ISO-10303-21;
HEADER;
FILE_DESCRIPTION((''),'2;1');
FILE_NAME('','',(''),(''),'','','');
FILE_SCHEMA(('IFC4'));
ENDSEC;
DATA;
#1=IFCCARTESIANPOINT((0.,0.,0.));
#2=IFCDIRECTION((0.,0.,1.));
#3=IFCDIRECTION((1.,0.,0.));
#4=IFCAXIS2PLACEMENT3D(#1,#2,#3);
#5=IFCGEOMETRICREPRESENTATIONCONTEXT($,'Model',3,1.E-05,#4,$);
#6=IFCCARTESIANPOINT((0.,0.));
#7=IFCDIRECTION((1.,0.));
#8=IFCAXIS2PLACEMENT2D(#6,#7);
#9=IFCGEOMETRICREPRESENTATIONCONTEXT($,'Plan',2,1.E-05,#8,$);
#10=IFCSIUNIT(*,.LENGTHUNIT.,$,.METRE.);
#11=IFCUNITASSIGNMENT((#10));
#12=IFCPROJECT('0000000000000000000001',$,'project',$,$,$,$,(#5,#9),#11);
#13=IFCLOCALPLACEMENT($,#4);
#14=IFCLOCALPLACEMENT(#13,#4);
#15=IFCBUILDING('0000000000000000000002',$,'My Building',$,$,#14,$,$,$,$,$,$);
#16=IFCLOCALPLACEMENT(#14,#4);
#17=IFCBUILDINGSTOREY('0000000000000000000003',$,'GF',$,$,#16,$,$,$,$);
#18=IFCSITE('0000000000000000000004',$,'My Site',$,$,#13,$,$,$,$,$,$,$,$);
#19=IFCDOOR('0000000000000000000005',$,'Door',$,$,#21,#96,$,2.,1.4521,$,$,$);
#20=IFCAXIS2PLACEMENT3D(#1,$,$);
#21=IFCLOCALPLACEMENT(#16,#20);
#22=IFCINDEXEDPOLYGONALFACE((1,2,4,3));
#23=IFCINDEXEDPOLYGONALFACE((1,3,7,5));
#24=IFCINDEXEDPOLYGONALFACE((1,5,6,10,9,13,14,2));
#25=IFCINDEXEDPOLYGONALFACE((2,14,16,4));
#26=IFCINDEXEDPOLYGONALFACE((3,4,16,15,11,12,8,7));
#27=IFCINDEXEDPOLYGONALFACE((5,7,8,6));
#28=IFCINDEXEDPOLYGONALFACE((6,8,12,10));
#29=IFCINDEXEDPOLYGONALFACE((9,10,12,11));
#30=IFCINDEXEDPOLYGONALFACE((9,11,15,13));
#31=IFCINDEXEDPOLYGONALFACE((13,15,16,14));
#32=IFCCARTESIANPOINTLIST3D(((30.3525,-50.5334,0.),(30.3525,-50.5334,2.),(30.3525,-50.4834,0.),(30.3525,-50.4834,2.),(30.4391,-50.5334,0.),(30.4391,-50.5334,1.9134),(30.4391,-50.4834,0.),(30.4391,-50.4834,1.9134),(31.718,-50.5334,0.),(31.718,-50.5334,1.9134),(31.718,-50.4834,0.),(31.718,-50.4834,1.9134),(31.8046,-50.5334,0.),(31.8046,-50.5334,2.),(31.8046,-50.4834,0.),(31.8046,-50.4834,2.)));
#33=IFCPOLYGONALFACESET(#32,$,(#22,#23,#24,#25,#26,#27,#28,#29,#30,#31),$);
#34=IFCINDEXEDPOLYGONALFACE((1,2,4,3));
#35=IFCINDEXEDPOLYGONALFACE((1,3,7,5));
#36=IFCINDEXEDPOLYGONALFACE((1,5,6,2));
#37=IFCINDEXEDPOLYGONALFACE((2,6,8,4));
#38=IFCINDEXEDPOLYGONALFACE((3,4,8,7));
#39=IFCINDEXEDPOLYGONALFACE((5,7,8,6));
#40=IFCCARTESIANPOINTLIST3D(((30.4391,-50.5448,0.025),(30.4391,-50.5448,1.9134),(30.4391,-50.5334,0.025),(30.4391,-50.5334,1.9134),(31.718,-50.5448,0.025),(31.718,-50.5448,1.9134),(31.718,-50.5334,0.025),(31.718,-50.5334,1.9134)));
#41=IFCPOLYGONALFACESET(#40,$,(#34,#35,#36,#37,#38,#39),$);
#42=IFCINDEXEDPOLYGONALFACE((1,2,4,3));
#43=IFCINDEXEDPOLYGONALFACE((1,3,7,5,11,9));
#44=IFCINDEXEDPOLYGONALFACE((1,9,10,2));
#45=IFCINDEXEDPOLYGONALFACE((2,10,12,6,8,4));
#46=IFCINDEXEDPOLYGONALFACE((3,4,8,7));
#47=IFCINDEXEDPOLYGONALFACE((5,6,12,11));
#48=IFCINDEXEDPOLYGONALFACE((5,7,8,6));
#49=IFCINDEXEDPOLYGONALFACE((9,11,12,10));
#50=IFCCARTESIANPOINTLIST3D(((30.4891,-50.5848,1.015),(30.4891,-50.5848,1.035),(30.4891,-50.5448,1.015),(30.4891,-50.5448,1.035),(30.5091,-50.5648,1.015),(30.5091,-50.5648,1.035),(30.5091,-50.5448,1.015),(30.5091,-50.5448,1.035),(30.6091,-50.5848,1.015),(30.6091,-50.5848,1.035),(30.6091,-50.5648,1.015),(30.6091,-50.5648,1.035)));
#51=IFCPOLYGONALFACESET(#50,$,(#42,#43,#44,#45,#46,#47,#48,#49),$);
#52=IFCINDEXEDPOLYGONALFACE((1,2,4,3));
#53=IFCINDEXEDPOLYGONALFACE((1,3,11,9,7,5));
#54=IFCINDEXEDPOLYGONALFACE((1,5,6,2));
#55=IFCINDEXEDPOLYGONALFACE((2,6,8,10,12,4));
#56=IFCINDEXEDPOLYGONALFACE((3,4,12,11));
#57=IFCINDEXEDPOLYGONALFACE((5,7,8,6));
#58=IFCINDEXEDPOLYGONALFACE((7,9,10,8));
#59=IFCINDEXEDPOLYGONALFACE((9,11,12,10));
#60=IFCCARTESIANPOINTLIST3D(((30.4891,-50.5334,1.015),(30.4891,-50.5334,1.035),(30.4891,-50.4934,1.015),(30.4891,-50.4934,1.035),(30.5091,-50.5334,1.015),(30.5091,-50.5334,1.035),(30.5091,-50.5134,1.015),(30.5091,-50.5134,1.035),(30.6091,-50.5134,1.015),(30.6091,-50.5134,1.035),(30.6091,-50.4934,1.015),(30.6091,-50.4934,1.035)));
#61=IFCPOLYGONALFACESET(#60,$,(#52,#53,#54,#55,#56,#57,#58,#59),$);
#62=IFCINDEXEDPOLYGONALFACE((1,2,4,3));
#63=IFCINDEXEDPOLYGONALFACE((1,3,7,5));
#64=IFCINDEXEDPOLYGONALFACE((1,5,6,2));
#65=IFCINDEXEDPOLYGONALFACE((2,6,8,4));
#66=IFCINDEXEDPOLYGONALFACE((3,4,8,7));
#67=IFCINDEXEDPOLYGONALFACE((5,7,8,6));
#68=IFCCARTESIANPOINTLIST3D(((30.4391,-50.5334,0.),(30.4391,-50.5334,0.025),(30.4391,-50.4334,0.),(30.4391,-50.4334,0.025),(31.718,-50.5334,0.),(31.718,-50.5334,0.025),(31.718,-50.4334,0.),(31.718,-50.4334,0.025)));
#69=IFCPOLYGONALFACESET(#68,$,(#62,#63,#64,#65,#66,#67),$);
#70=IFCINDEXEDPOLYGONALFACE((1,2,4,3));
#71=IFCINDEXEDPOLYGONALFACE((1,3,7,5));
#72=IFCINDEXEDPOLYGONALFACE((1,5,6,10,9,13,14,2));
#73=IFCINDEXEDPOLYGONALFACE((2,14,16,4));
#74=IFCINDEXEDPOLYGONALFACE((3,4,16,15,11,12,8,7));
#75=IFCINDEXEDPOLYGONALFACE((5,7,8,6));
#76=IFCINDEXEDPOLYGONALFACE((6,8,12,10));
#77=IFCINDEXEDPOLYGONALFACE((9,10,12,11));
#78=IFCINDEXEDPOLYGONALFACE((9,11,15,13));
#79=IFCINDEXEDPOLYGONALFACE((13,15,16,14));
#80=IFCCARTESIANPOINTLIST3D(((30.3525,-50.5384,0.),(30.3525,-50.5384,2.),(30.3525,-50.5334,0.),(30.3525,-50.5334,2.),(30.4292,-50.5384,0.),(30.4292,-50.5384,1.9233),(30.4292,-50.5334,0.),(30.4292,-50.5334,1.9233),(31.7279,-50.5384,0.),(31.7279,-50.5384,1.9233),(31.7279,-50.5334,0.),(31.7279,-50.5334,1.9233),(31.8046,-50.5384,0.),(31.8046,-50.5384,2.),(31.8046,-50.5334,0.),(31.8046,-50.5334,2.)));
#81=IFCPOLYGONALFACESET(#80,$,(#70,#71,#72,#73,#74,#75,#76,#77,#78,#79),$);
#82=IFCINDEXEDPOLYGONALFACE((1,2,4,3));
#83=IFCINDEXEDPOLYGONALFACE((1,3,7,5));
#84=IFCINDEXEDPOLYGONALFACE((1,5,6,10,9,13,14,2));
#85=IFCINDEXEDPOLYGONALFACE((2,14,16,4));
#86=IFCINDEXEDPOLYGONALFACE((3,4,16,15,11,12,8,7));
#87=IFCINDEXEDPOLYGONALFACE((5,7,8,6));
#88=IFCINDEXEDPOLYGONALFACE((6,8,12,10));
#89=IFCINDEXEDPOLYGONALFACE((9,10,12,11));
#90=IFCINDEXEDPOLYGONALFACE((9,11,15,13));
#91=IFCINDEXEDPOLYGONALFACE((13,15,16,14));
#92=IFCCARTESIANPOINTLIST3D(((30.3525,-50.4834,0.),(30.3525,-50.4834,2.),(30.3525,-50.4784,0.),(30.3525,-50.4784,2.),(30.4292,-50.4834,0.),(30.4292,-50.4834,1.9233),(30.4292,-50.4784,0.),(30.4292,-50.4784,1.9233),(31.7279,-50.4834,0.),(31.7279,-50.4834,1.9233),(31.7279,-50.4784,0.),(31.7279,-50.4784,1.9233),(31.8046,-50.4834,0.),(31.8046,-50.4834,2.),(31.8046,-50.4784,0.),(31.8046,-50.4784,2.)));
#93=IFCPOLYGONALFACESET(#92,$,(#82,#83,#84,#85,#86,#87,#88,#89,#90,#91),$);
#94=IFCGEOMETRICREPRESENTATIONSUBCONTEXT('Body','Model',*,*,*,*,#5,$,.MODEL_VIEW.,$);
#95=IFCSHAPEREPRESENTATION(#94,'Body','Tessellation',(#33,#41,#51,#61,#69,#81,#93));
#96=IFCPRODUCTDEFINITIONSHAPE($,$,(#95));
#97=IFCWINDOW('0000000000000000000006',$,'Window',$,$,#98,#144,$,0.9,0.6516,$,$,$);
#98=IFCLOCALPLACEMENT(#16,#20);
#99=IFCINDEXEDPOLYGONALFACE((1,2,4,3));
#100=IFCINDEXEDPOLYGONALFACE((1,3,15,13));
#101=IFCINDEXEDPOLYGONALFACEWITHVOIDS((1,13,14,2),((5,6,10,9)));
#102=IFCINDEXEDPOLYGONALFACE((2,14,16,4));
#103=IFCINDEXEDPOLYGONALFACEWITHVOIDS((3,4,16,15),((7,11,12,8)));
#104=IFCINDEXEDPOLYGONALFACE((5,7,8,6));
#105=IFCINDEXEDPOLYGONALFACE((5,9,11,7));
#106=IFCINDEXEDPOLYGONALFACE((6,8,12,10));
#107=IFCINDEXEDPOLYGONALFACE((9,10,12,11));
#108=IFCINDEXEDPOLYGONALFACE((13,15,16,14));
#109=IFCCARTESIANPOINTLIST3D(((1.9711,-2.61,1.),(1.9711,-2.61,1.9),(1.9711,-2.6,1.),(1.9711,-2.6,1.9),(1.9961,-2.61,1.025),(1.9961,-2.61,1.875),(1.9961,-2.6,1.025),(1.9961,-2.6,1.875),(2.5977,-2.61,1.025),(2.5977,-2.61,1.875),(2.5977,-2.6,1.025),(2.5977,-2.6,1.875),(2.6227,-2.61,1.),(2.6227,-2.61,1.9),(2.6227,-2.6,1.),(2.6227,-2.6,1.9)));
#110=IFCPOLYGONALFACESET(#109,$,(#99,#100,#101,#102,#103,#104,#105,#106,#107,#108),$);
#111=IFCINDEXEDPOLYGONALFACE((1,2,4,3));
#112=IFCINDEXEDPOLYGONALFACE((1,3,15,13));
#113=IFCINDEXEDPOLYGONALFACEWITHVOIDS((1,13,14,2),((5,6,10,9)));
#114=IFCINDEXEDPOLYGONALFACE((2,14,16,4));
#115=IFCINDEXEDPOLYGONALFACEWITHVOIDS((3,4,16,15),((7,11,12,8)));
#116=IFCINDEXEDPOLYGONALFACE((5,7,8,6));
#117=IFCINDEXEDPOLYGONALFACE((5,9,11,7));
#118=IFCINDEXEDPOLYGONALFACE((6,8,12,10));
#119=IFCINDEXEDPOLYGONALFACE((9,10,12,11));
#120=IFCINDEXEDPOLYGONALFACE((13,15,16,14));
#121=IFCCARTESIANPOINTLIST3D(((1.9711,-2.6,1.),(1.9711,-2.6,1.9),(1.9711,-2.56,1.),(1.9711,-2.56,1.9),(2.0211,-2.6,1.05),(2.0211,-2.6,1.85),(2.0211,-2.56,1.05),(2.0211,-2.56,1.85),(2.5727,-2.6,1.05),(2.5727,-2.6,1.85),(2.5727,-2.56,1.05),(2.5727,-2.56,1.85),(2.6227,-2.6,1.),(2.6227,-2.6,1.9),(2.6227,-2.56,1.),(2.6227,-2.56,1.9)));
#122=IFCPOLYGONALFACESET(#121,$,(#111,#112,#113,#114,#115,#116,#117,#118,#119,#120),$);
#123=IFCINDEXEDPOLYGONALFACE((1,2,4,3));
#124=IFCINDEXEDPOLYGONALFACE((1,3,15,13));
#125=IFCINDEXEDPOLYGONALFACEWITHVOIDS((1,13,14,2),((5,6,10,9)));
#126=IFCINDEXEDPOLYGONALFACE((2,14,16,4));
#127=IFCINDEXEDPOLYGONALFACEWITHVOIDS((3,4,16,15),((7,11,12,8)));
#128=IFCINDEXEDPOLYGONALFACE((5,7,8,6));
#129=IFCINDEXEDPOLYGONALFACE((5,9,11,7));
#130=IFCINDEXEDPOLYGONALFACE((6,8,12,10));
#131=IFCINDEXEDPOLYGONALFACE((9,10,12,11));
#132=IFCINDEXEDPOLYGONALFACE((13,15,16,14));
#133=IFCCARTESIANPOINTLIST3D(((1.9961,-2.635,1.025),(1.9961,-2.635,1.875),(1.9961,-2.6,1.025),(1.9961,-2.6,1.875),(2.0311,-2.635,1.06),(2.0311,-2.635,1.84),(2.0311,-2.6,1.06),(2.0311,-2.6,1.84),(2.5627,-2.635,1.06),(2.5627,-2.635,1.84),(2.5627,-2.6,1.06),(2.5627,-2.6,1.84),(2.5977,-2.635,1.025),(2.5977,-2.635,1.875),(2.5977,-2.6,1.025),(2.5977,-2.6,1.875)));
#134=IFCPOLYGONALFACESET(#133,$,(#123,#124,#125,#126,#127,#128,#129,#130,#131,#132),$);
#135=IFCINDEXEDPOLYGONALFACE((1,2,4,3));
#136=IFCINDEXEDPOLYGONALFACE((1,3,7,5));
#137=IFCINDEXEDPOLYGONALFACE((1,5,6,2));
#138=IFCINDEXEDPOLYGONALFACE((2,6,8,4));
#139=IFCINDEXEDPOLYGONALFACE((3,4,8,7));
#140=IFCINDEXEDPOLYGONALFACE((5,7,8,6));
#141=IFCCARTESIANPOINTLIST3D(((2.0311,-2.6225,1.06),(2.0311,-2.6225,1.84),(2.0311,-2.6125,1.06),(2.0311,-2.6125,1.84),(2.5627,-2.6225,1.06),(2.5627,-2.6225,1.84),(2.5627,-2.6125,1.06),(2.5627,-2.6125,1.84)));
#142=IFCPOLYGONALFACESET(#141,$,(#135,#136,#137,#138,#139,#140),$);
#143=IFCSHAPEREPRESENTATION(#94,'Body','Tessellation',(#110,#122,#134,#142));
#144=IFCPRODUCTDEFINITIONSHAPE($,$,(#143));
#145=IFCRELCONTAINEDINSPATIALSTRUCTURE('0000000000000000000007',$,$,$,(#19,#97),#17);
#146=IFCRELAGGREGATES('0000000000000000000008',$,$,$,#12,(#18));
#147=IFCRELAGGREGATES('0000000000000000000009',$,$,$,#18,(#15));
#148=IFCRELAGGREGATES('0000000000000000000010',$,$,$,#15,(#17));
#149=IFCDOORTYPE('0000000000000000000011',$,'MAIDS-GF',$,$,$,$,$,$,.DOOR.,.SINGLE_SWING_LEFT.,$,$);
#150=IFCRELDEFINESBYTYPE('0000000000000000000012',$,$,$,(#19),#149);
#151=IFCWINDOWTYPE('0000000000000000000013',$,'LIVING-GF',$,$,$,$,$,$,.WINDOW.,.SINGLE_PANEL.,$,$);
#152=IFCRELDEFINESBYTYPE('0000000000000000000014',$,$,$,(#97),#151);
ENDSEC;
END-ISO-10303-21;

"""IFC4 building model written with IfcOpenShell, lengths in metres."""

from ifc_helpers import new_model, entity, si_unit, frame, origin_with_axes, origin_2d_with_axis, place, context, subcontext, project, spatial, line, indexed_curve, outline, extrude, shape, source, transform, mapped, type_object, type_shapes, element, save


model = new_model("IFC4")

# Units and contexts
model_context = context("Model", 3, precision=1e-05, world=origin_with_axes())
plan_context = context("Plan", 2, precision=1e-05, world=origin_2d_with_axis())
body_context_1 = subcontext(model_context, "Body", "Model", "MODEL_VIEW")
body_context_2 = subcontext(plan_context, "Body", "Plan", "PLAN_VIEW")
ifc_project = project(units=[si_unit("LENGTHUNIT", "METRE")], contexts=[model_context, plan_context])

# Site, building, storey
site_placement = place(None, origin_with_axes())
site = spatial("IfcSite", under=ifc_project, at=site_placement, Name="My Site")
building_placement = place(site_placement, origin_with_axes())
building = spatial("IfcBuilding", under=site, at=building_placement, Name="My Building")
storey_placement = place(building_placement, origin_with_axes())
storey = spatial("IfcBuildingStorey", under=building, at=storey_placement, Name="GF")

# Shared definitions
wall_1_placement = place(storey_placement, frame((0.2283, -2.61, 0.0), z_axis=(0.0, 0.0, 1.0), x_axis=(1.0, 0.0, 0.0)))
window_type_1 = type_object("IfcWindowType", Name="LIVING-GF", PartitioningType="SINGLE_PANEL", PredefinedType="WINDOW")
shared_shape_1 = source(origin_with_axes(), body_context_1, "Body", "SweptSolid", [
    extrude(outline(indexed_curve([(0.0, 0.0), (0.6516, 0.0), (0.6516, 0.9), (0.0, 0.9)], segments=[line(1, 2, 3, 4, 1)]), holes=[indexed_curve([(0.025, 0.025), (0.6266, 0.025), (0.6266, 0.875), (0.025, 0.875)], segments=[line(1, 2, 3, 4, 1)])]), frame((0.0, 0.09, 0.0), z_axis=(0.0, -1.0, 0.0), x_axis=(1.0, 0.0, 0.0)), (0.0, 0.0, -1.0), 0.01),
    extrude(outline(indexed_curve([(0.0, 0.0), (0.6516, 0.0), (0.6516, 0.9), (0.0, 0.9)], segments=[line(1, 2, 3, 4, 1)]), holes=[indexed_curve([(0.05, 0.05), (0.6016, 0.05), (0.6016, 0.85), (0.05, 0.85)], segments=[line(1, 2, 3, 4, 1)])]), frame((0.0, 0.05, 0.0), z_axis=(0.0, -1.0, 0.0), x_axis=(1.0, 0.0, 0.0)), (0.0, 0.0, -1.0), 0.04),
    extrude(outline(indexed_curve([(0.0, 0.0), (0.6016, 0.0), (0.6016, 0.85), (0.0, 0.85)], segments=[line(1, 2, 3, 4, 1)]), holes=[indexed_curve([(0.035, 0.035), (0.5666, 0.035), (0.5666, 0.815), (0.035, 0.815)], segments=[line(1, 2, 3, 4, 1)])]), frame((0.025, 0.09, 0.025), z_axis=(0.0, -1.0, 0.0), x_axis=(1.0, 0.0, 0.0)), (0.0, 0.0, -1.0), 0.035),
    extrude(outline(indexed_curve([(0.035, 0.035), (0.5666, 0.035), (0.5666, 0.815), (0.035, 0.815)], segments=[line(1, 2, 3, 4, 1)])), frame((0.025, 0.1025, 0.025), z_axis=(0.0, -1.0, 0.0), x_axis=(1.0, 0.0, 0.0)), (0.0, 0.0, -1.0), 0.01),
])
shared_shape_2 = source(origin_with_axes(), body_context_2, "Body", "Curve2D", [
    entity("IfcIndexedPolyCurve", entity("IfcCartesianPointList2D", [[0.05, 0.05], [0.6016, 0.05]])),
    entity("IfcIndexedPolyCurve", entity("IfcCartesianPointList2D", [[0.0, 0.1], [0.025, 0.1], [0.025, 0.09], [0.05, 0.09], [0.05, 0.05], [0.0, 0.05]]), [entity("IfcLineIndex", [1, 2, 3, 4, 5, 6, 1])]),
    entity("IfcIndexedPolyCurve", entity("IfcCartesianPointList2D", [[0.6516, 0.1], [0.6266, 0.1], [0.6266, 0.09], [0.6016, 0.09], [0.6016, 0.05], [0.6516, 0.05]]), [entity("IfcLineIndex", [1, 2, 3, 4, 5, 6, 1])]),
    entity("IfcIndexedPolyCurve", entity("IfcCartesianPointList2D", [[0.025, 0.09], [0.06, 0.09], [0.06, 0.125], [0.025, 0.125]]), [entity("IfcLineIndex", [1, 2, 3, 4, 1])]),
    entity("IfcIndexedPolyCurve", entity("IfcCartesianPointList2D", [[0.6266, 0.09], [0.5916, 0.09], [0.5916, 0.125], [0.6266, 0.125]]), [entity("IfcLineIndex", [1, 2, 3, 4, 1])]),
    entity("IfcIndexedPolyCurve", entity("IfcCartesianPointList2D", [[0.06, 0.09], [0.5916, 0.09]])),
    entity("IfcIndexedPolyCurve", entity("IfcCartesianPointList2D", [[0.06, 0.125], [0.5916, 0.125]])),
    entity("IfcIndexedPolyCurve", entity("IfcCartesianPointList2D", [[0.06, 0.1075], [0.5916, 0.1075]])),
])
type_shapes(window_type_1, [shared_shape_1, shared_shape_2])

# Door
door_type_1 = type_object("IfcDoorType", Name="MAIDS-GF", OperationType="SINGLE_SWING_LEFT", PredefinedType="DOOR")
shared_shape_3 = source(origin_with_axes(), body_context_1, "Body", "SweptSolid", [
    extrude(outline(indexed_curve([(0.0, 0.0), (0.0, 2.0), (1.4521, 2.0), (1.4521, 0.0), (1.3655, 0.0), (1.3655, 1.9134), (0.0866, 1.9134), (0.0866, 0.0)], segments=[line(1, 2, 3, 4, 5, 6, 7, 8, 1)])), frame((0.0, 0.0, 0.0), z_axis=(0.0, -1.0, 0.0), x_axis=(1.0, 0.0, 0.0)), (0.0, 0.0, -1.0), 0.05),
    extrude(outline(indexed_curve([(0.0, 0.0), (1.2788, 0.0), (1.2788, 0.0114), (0.0, 0.0114)], segments=[line(1, 2, 3, 4, 1)])), frame((0.0866, -0.0114, 0.025), z_axis=(0.0, 0.0, 1.0), x_axis=(1.0, 0.0, 0.0)), (0.0, 0.0, 1.0), 1.8884),
    extrude(outline(indexed_curve([(0.0, 0.0), (0.0, -0.04), (0.12, -0.04), (0.12, -0.02), (0.02, -0.02), (0.02, 0.0)], segments=[line(1, 2, 3, 4, 5, 6, 1)])), frame((0.1366, -0.0114, 1.015), z_axis=(0.0, 0.0, 1.0), x_axis=(1.0, 0.0, 0.0)), (0.0, 0.0, 1.0), 0.02),
    extrude(outline(indexed_curve([(0.0, 0.0), (0.0, 0.04), (0.12, 0.04), (0.12, 0.02), (0.02, 0.02), (0.02, 0.0)], segments=[line(1, 2, 3, 4, 5, 6, 1)])), frame((0.1366, 0.0, 1.015), z_axis=(0.0, 0.0, 1.0), x_axis=(1.0, 0.0, 0.0)), (0.0, 0.0, 1.0), 0.02),
    extrude(outline(indexed_curve([(0.0, 0.0), (1.2788, 0.0), (1.2788, 0.1), (0.0, 0.1)], segments=[line(1, 2, 3, 4, 1)])), frame((0.0866, 0.0, 0.0), z_axis=(0.0, 0.0, 1.0), x_axis=(1.0, 0.0, 0.0)), (0.0, 0.0, 1.0), 0.025),
    extrude(outline(indexed_curve([(0.0, 0.0), (0.0, 2.0), (1.4521, 2.0), (1.4521, 0.0), (1.3754, 0.0), (1.3754, 1.9233), (0.0767, 1.9233), (0.0767, 0.0)], segments=[line(1, 2, 3, 4, 5, 6, 7, 8, 1)])), frame((0.0, -0.005, 0.0), z_axis=(0.0, -1.0, 0.0), x_axis=(1.0, 0.0, 0.0)), (0.0, 0.0, -1.0), 0.005),
    extrude(outline(indexed_curve([(0.0, 0.0), (0.0, 2.0), (1.4521, 2.0), (1.4521, 0.0), (1.3754, 0.0), (1.3754, 1.9233), (0.0767, 1.9233), (0.0767, 0.0)], segments=[line(1, 2, 3, 4, 5, 6, 7, 8, 1)])), frame((0.0, 0.05, 0.0), z_axis=(0.0, -1.0, 0.0), x_axis=(1.0, 0.0, 0.0)), (0.0, 0.0, -1.0), 0.005),
])
shared_shape_4 = source(origin_with_axes(), body_context_2, "Body", "Curve2D", [
    entity("IfcIndexedPolyCurve", entity("IfcCartesianPointList2D", [[0.0, 0.0], [0.0866, 0.0], [0.0866, 0.05], [0.0, 0.05]]), [entity("IfcLineIndex", [1, 2, 3, 4, 1])]),
    entity("IfcIndexedPolyCurve", entity("IfcCartesianPointList2D", [[1.4521, 0.0], [1.3655, 0.0], [1.3655, 0.05], [1.4521, 0.05]]), [entity("IfcLineIndex", [1, 2, 3, 4, 1])]),
    entity("IfcIndexedPolyCurve", entity("IfcCartesianPointList2D", [[2.0049, -0.0114], [0.7261, -0.0114], [0.7261, 0.0], [2.0049, 0.0]]), [entity("IfcLineIndex", [1, 2, 3, 4, 1])]),
])
type_shapes(door_type_1, [shared_shape_3, shared_shape_4])
door_1_placement = place(storey_placement, frame((30.3525, -50.5334, 0.0), z_axis=(0.0, 0.0, 1.0), x_axis=(1.0, 0.0, 0.0)))
element("IfcDoor", 1, at=door_1_placement, inside=storey, type_object=door_type_1, Name="Door", OverallHeight=2.0, OverallWidth=1.4521, shapes=[
    shape(body_context_1, "Body", "MappedRepresentation", [mapped(shared_shape_3, transform((0.0, 0.0, 0.0), x_axis=(1.0, 0.0, 0.0), y_axis=(0.0, 1.0, 0.0), z_axis=(0.0, 0.0, 1.0), scale=1.0))]),
    shape(body_context_2, "Body", "MappedRepresentation", [mapped(shared_shape_4, transform((0.0, 0.0, 0.0), x_axis=(1.0, 0.0, 0.0), y_axis=(0.0, 1.0, 0.0), z_axis=(0.0, 0.0, 1.0), scale=1.0))]),
])

# Window
placement_1 = place(wall_1_placement, frame((2.3944, 0.1, 1.0), z_axis=(0.0, 0.0, 1.0), x_axis=(-1.0, 0.0, 0.0)))
window_1_placement = place(placement_1, frame((0.0, 0.0, 0.0), z_axis=(0.0, 0.0, 1.0), x_axis=(1.0, 0.0, 0.0)))
element("IfcWindow", 2, at=window_1_placement, inside=storey, type_object=window_type_1, Name="Window", OverallHeight=0.9, OverallWidth=0.6516, shapes=[
    shape(body_context_1, "Body", "MappedRepresentation", [mapped(shared_shape_1, transform((0.0, 0.0, 0.0), x_axis=(1.0, 0.0, 0.0), y_axis=(0.0, 1.0, 0.0), z_axis=(0.0, 0.0, 1.0), scale=1.0))]),
    shape(body_context_2, "Body", "MappedRepresentation", [mapped(shared_shape_2, transform((0.0, 0.0, 0.0), x_axis=(1.0, 0.0, 0.0), y_axis=(0.0, 1.0, 0.0), z_axis=(0.0, 0.0, 1.0), scale=1.0))]),
])

save(model, "model.ifc")
